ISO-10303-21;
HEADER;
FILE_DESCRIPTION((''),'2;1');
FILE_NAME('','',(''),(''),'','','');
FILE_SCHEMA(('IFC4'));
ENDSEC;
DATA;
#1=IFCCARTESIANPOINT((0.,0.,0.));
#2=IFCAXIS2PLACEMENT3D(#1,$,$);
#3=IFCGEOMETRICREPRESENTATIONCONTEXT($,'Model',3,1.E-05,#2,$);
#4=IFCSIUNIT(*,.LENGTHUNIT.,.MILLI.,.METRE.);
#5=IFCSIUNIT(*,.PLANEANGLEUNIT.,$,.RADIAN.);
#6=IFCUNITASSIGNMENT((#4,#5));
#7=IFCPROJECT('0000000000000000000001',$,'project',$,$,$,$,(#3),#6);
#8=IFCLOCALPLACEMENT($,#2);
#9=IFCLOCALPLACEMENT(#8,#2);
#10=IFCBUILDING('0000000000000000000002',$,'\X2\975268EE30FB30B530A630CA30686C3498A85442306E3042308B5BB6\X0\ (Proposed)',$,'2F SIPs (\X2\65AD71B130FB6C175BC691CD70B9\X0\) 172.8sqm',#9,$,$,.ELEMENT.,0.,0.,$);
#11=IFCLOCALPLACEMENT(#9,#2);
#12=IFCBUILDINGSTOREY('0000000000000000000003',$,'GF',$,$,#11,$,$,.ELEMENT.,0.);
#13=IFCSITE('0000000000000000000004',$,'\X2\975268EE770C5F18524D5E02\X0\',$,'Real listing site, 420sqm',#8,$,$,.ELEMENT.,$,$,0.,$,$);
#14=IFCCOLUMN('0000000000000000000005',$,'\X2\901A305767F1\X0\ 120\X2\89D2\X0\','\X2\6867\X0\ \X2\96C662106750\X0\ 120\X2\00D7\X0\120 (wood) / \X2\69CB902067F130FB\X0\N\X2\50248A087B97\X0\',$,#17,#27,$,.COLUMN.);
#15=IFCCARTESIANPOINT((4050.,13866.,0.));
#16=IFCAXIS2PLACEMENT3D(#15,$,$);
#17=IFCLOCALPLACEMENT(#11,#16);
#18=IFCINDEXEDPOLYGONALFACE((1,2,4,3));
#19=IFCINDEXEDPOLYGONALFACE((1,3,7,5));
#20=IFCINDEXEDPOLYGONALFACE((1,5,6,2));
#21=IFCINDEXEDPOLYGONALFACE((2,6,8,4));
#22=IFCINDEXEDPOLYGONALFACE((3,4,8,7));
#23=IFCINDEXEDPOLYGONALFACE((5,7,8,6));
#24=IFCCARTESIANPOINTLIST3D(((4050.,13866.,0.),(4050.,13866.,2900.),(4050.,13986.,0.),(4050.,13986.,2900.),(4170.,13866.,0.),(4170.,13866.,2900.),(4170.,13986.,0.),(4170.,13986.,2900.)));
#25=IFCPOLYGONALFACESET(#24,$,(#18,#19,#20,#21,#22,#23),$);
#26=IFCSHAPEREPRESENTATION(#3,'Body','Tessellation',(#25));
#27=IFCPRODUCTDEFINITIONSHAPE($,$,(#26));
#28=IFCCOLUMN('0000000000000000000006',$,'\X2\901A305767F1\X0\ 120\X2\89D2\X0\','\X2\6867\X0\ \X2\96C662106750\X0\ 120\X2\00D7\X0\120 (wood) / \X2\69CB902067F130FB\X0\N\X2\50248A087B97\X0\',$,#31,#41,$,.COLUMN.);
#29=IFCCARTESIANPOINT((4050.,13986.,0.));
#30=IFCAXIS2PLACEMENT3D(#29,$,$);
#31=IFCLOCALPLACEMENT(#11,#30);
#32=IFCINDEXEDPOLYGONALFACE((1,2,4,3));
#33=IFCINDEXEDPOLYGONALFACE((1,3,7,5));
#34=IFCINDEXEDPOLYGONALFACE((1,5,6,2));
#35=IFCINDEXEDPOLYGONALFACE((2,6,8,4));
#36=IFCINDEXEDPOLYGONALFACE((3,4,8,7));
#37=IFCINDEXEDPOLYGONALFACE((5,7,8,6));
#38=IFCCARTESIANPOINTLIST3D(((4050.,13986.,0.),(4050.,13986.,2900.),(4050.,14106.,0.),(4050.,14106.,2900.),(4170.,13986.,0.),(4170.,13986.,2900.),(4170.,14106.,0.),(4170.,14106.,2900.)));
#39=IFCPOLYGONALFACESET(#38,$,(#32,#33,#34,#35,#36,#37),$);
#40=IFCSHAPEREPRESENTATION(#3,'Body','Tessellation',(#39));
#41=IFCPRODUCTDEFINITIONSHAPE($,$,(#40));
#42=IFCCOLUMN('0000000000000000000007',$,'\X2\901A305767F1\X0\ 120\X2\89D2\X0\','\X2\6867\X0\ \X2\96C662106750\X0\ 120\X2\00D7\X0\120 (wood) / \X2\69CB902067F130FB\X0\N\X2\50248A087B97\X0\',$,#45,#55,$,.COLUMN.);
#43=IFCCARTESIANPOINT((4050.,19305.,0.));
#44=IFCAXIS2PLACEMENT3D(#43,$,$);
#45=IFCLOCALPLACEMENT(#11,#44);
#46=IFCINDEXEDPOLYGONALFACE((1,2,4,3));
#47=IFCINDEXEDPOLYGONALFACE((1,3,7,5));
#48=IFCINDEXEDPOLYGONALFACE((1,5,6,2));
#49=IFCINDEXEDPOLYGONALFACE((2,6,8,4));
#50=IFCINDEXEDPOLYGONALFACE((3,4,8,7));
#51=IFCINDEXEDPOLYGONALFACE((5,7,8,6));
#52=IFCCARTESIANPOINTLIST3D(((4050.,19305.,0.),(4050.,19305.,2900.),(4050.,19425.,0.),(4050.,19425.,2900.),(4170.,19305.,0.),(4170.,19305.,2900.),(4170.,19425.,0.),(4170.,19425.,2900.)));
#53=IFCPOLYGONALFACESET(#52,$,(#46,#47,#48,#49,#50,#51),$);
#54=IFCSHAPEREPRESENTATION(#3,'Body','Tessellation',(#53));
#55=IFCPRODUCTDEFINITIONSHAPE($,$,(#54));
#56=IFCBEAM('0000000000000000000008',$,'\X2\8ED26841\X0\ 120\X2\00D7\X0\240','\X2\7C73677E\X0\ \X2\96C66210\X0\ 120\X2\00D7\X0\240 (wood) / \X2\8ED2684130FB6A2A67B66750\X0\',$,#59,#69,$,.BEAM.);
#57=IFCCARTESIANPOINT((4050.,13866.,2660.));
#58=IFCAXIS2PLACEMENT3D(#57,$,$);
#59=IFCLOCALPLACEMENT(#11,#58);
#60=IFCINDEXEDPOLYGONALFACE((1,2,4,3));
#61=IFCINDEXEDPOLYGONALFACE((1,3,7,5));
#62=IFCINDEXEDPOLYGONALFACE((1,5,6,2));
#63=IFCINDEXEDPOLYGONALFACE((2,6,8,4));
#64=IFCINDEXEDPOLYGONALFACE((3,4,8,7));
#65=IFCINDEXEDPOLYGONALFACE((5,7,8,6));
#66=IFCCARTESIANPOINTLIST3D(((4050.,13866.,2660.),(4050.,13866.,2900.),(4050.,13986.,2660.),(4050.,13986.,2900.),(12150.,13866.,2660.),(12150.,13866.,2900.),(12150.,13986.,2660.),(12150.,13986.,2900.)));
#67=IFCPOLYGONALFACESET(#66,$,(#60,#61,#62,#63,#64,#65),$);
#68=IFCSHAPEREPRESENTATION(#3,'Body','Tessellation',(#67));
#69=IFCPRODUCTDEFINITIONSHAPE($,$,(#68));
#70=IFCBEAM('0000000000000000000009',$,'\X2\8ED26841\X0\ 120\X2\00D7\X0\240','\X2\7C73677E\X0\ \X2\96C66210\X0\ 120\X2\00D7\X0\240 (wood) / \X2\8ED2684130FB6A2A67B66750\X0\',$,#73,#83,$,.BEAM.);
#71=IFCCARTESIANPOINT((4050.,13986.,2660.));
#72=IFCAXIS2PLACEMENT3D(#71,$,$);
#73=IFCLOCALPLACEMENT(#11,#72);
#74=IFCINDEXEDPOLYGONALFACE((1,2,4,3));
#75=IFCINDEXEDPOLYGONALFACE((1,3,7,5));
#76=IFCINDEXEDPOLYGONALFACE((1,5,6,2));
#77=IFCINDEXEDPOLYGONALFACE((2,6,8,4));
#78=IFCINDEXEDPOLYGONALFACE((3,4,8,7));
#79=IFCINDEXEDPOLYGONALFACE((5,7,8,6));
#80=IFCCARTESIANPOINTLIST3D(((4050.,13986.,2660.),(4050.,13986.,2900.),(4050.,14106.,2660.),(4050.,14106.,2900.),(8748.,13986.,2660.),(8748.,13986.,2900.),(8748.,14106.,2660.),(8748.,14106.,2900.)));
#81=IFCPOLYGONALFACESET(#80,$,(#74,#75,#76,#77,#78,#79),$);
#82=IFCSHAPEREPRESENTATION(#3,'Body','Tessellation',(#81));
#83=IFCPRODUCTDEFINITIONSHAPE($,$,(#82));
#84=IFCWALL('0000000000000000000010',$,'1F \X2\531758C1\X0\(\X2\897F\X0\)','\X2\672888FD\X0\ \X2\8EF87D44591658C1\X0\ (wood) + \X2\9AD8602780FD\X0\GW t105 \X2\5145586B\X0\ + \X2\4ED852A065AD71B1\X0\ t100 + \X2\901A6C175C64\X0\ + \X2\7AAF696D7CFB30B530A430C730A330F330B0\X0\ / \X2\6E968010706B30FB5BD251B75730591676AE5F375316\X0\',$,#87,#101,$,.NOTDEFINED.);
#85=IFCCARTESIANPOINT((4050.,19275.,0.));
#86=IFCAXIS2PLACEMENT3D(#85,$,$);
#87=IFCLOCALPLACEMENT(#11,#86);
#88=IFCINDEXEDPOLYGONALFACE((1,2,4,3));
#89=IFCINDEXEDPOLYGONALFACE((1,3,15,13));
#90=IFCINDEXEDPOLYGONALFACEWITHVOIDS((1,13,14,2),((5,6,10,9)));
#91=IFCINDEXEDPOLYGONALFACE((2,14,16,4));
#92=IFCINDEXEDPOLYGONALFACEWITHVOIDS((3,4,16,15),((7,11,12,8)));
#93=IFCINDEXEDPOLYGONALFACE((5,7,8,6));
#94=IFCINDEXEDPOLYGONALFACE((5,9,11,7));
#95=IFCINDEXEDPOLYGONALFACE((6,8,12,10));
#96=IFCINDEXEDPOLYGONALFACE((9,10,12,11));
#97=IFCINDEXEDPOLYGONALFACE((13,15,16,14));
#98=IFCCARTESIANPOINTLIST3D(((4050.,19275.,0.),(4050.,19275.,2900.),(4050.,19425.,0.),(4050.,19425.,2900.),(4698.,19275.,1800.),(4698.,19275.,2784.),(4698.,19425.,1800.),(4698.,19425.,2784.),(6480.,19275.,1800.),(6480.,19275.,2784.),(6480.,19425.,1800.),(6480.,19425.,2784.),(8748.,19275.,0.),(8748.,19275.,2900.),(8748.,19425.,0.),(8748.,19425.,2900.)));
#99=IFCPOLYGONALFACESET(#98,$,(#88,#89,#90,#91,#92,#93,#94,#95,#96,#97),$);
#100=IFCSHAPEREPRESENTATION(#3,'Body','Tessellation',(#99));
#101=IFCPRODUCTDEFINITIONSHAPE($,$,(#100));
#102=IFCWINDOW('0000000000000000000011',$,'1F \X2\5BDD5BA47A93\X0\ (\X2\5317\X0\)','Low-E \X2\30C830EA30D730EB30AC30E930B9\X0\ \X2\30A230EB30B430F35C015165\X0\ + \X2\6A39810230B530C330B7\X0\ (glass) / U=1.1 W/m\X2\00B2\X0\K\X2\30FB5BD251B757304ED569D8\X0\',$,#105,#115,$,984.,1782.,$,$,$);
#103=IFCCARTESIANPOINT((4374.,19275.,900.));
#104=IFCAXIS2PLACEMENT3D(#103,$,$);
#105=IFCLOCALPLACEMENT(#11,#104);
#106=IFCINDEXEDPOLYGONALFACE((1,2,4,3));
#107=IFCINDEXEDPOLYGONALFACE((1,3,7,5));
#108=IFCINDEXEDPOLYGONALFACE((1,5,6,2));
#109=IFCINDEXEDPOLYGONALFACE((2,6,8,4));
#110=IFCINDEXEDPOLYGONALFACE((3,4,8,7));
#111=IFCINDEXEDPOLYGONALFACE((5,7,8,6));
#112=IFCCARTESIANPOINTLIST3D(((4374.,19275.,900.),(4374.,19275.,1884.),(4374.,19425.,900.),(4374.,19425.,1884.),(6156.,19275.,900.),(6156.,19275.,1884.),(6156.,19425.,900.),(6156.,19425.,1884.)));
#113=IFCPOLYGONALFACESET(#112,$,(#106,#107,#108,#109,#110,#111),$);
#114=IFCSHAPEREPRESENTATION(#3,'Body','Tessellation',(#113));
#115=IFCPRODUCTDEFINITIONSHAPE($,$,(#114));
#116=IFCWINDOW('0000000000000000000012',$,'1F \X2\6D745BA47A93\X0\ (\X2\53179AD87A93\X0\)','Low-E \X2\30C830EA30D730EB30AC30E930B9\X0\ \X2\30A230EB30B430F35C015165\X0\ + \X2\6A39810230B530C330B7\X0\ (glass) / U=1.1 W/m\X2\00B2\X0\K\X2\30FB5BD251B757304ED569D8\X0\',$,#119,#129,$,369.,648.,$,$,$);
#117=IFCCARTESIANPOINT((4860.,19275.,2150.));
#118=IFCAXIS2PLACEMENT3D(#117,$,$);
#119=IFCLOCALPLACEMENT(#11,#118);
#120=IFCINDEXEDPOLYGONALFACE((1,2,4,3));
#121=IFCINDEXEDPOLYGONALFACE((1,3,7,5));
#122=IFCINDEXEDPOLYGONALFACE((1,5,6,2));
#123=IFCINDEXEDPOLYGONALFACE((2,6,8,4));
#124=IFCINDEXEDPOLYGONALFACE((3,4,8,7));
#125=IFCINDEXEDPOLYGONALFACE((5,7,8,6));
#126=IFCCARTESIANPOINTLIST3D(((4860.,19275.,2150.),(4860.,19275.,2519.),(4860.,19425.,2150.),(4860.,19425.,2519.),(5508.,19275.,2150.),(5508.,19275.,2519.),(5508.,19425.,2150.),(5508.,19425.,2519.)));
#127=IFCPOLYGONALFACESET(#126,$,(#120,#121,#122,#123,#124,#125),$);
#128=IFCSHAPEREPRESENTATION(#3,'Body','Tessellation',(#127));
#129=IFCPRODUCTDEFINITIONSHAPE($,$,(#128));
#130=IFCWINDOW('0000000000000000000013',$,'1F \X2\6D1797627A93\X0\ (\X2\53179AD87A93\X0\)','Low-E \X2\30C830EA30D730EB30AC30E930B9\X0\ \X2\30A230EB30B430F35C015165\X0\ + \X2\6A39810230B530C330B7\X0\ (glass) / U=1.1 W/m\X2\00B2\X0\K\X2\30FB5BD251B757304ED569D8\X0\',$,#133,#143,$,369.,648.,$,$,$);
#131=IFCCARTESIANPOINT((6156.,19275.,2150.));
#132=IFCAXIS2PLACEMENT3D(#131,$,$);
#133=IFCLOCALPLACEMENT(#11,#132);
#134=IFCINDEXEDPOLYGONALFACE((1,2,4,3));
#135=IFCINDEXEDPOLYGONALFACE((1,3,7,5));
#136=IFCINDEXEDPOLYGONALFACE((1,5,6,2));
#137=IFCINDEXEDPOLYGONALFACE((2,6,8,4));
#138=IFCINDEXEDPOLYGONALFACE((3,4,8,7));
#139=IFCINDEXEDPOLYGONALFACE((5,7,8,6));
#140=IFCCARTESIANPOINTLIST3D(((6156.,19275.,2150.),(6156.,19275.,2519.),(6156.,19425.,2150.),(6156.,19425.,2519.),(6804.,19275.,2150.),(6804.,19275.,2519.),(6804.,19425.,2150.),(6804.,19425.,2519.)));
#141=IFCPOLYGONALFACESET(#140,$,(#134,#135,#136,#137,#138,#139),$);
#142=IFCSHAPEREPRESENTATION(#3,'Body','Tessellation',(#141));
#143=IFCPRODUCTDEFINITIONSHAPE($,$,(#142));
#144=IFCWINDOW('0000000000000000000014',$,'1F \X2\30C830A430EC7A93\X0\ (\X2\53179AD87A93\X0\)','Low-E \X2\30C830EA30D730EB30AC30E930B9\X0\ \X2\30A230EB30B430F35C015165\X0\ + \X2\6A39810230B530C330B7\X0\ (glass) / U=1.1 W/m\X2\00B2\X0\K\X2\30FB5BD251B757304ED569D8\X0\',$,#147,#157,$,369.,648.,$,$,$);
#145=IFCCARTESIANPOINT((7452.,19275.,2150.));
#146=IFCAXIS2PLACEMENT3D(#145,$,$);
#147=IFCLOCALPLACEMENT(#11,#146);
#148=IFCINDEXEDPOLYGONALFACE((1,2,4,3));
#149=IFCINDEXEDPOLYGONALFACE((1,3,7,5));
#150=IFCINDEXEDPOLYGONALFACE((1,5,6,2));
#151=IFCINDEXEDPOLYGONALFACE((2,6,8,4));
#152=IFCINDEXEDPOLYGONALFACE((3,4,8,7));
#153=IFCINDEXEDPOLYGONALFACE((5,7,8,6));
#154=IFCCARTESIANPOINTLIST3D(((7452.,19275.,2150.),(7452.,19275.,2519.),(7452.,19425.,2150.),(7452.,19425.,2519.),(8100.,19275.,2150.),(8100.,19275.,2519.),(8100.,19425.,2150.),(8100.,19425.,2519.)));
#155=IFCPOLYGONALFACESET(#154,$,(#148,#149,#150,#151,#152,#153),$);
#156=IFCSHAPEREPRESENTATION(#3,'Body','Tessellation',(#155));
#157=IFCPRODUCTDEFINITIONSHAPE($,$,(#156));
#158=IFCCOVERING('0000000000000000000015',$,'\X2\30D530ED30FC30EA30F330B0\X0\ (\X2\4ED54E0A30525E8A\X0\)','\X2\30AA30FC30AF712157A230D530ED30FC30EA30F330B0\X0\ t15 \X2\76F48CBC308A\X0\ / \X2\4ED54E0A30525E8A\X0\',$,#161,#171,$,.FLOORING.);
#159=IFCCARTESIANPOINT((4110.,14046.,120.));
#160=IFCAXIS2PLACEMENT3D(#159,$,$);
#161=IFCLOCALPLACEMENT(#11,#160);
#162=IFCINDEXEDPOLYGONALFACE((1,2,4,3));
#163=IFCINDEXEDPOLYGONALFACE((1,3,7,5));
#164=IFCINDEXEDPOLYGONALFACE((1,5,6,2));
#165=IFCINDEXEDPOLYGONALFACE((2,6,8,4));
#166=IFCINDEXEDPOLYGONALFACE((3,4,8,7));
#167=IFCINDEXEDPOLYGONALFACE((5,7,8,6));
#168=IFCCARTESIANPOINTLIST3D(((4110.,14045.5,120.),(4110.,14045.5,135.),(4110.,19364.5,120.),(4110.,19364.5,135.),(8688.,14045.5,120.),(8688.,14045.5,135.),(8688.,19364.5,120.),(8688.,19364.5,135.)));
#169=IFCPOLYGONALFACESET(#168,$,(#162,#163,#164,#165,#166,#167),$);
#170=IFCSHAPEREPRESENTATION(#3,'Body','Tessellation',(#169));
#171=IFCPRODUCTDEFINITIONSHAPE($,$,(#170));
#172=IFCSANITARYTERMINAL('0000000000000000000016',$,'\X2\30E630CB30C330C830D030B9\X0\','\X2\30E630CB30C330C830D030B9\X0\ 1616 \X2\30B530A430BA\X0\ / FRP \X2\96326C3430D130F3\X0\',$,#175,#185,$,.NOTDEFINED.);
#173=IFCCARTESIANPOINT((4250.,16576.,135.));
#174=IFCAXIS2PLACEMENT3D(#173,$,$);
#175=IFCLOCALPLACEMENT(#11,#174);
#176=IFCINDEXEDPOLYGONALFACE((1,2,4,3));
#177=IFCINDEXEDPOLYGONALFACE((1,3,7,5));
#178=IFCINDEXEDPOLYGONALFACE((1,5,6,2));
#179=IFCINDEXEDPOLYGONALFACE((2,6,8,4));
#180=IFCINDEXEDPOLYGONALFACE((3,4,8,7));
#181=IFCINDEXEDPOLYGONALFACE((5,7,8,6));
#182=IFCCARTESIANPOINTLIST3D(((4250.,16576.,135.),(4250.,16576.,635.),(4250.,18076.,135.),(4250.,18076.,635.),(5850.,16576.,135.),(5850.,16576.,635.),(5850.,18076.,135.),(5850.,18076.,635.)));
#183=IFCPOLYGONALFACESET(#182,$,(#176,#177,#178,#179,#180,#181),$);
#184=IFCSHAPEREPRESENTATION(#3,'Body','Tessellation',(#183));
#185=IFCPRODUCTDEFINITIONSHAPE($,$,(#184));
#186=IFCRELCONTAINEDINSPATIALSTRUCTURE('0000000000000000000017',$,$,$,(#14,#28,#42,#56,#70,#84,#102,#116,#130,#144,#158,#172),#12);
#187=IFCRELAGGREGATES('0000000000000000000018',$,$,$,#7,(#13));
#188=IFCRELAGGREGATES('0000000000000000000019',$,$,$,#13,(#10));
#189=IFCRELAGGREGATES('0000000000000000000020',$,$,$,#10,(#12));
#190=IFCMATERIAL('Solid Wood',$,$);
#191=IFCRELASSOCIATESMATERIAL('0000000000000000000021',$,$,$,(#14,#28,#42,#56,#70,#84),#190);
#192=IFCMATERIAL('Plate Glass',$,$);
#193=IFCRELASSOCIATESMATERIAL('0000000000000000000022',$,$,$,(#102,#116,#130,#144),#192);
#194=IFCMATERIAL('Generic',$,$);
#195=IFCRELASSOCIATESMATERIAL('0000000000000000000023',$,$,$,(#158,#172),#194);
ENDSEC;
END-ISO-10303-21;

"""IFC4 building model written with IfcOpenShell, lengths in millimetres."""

from ifc_helpers import new_model, si_unit, frame, frame_2d, origin, place, context, project, spatial, rectangle, extrude, material, element, fill, save


model = new_model("IFC4")

# Units and contexts
model_context = context("Model", 3, precision=1e-05, world=origin())
ifc_project = project(units=[si_unit("LENGTHUNIT", "METRE", prefix="MILLI"), si_unit("PLANEANGLEUNIT", "RADIAN")], contexts=[model_context])

# Site, building, storey
site_placement = place(None, origin())
site = spatial("IfcSite", under=ifc_project, at=site_placement, Name="青森県弘前市", ObjectType="Real listing site, 420sqm", CompositionType="ELEMENT", RefElevation=0.0)
building_placement = place(site_placement, origin())
building = spatial("IfcBuilding", under=site, at=building_placement, Name="青森・サウナと水風呂のある家 (Proposed)", ObjectType="2F SIPs (断熱・気密重点) 172.8sqm", CompositionType="ELEMENT", ElevationOfRefHeight=0.0, ElevationOfTerrain=0.0)
storey_placement = place(building_placement, origin())
storey = spatial("IfcBuildingStorey", under=building, at=storey_placement, Name="GF", CompositionType="ELEMENT", Elevation=0.0)

# Columns
ifc_material_1 = material(Name="Solid Wood")
column_1_placement = place(storey_placement, frame((4050.0, 13866.0, 0.0)))
element("IfcColumn", 1, at=column_1_placement, inside=storey, material=ifc_material_1, Name="通し柱 120角", Description="桧 集成材 120×120 (wood) / 構造柱・N値計算", PredefinedType="COLUMN", context=model_context, shape_type="SweptSolid", body=[
    extrude(rectangle(XDim=120.0, YDim=120.0, at=frame_2d((60.0, 60.0))), frame((4050.0, 13866.0, 0.0)), (0.0, 0.0, 1.0), 2900.0),
])
column_2_placement = place(storey_placement, frame((4050.0, 13986.0, 0.0)))
element("IfcColumn", 2, at=column_2_placement, inside=storey, material=ifc_material_1, Name="通し柱 120角", Description="桧 集成材 120×120 (wood) / 構造柱・N値計算", PredefinedType="COLUMN", context=model_context, shape_type="SweptSolid", body=[
    extrude(rectangle(XDim=120.0, YDim=120.0, at=frame_2d((60.0, 60.0))), frame((4050.0, 13986.0, 0.0)), (0.0, 0.0, 1.0), 2900.0),
])
column_3_placement = place(storey_placement, frame((4050.0, 19305.0, 0.0)))
element("IfcColumn", 3, at=column_3_placement, inside=storey, material=ifc_material_1, Name="通し柱 120角", Description="桧 集成材 120×120 (wood) / 構造柱・N値計算", PredefinedType="COLUMN", context=model_context, shape_type="SweptSolid", body=[
    extrude(rectangle(XDim=120.0, YDim=120.0, at=frame_2d((60.0, 60.0))), frame((4050.0, 19305.0, 0.0)), (0.0, 0.0, 1.0), 2900.0),
])

# Beams
beam_1_placement = place(storey_placement, frame((4050.0, 13866.0, 2660.0)))
element("IfcBeam", 4, at=beam_1_placement, inside=storey, material=ifc_material_1, Name="軒桁 120×240", Description="米松 集成 120×240 (wood) / 軒桁・横架材", PredefinedType="BEAM", context=model_context, shape_type="SweptSolid", body=[
    extrude(rectangle(XDim=8100.0, YDim=120.0, at=frame_2d((4050.0, 60.0))), frame((4050.0, 13866.0, 2660.0)), (0.0, 0.0, 1.0), 240.0),
])
beam_2_placement = place(storey_placement, frame((4050.0, 13986.0, 2660.0)))
element("IfcBeam", 5, at=beam_2_placement, inside=storey, material=ifc_material_1, Name="軒桁 120×240", Description="米松 集成 120×240 (wood) / 軒桁・横架材", PredefinedType="BEAM", context=model_context, shape_type="SweptSolid", body=[
    extrude(rectangle(XDim=4698.0, YDim=120.0, at=frame_2d((2349.0, 60.0))), frame((4050.0, 13986.0, 2660.0)), (0.0, 0.0, 1.0), 240.0),
])

# Wall, openings, windows
wall_1_placement = place(storey_placement, frame((4050.0, 19275.0, 0.0)))
wall_1 = element("IfcWall", 6, at=wall_1_placement, inside=storey, material=ifc_material_1, Name="1F 北壁(西)", Description="木製 軸組外壁 (wood) + 高性能GW t105 充填 + 付加断熱 t100 + 通気層 + 窯業系サイディング / 準耐火・寒冷地外皮強化", PredefinedType="NOTDEFINED", context=model_context, shape_type="SweptSolid", body=[
    extrude(rectangle(XDim=4698.0, YDim=150.0, at=frame_2d((2349.0, 75.0))), frame((4050.0, 19275.0, 0.0)), (0.0, 0.0, 1.0), 2900.0),
])
opening_1_placement = place(storey_placement, frame((4374.0, 19275.0, 900.0)))
opening_1 = element("IfcOpeningElement", 7, at=opening_1_placement, cuts=wall_1, PredefinedType="NOTDEFINED", context=model_context, shape_type="SweptSolid", body=[
    extrude(rectangle(XDim=1782.0, YDim=150.0, at=frame_2d((891.0, 75.0))), frame((4374.0, 19275.0, 900.0)), (0.0, 0.0, 1.0), 984.0),
])
opening_2_placement = place(storey_placement, frame((4860.0, 19275.0, 2150.0)))
opening_2 = element("IfcOpeningElement", 8, at=opening_2_placement, cuts=wall_1, PredefinedType="NOTDEFINED", context=model_context, shape_type="SweptSolid", body=[
    extrude(rectangle(XDim=648.0, YDim=150.0, at=frame_2d((324.0, 75.0))), frame((4860.0, 19275.0, 2150.0)), (0.0, 0.0, 1.0), 369.0),
])
opening_3_placement = place(storey_placement, frame((6156.0, 19275.0, 2150.0)))
opening_3 = element("IfcOpeningElement", 9, at=opening_3_placement, cuts=wall_1, PredefinedType="NOTDEFINED", context=model_context, shape_type="SweptSolid", body=[
    extrude(rectangle(XDim=648.0, YDim=150.0, at=frame_2d((324.0, 75.0))), frame((6156.0, 19275.0, 2150.0)), (0.0, 0.0, 1.0), 369.0),
])
opening_4_placement = place(storey_placement, frame((7452.0, 19275.0, 2150.0)))
opening_4 = element("IfcOpeningElement", 10, at=opening_4_placement, cuts=wall_1, PredefinedType="NOTDEFINED", context=model_context, shape_type="SweptSolid", body=[
    extrude(rectangle(XDim=648.0, YDim=150.0, at=frame_2d((324.0, 75.0))), frame((7452.0, 19275.0, 2150.0)), (0.0, 0.0, 1.0), 369.0),
])
ifc_material_2 = material(Name="Plate Glass")
window_1_placement = place(storey_placement, frame((4374.0, 19275.0, 900.0)))
window_1 = element("IfcWindow", 11, at=window_1_placement, inside=storey, material=ifc_material_2, Name="1F 寝室窓 (北)", Description="Low-E トリプルガラス アルゴン封入 + 樹脂サッシ (glass) / U=1.1 W/m²K・寒冷地仕様", OverallHeight=984.0, OverallWidth=1782.0, context=model_context, shape_type="SweptSolid", body=[
    extrude(rectangle(XDim=1782.0, YDim=150.0, at=frame_2d((891.0, 75.0))), frame((4374.0, 19275.0, 900.0)), (0.0, 0.0, 1.0), 984.0),
])
fill(opening_1, window_1)
window_2_placement = place(storey_placement, frame((4860.0, 19275.0, 2150.0)))
window_2 = element("IfcWindow", 12, at=window_2_placement, inside=storey, material=ifc_material_2, Name="1F 浴室窓 (北高窓)", Description="Low-E トリプルガラス アルゴン封入 + 樹脂サッシ (glass) / U=1.1 W/m²K・寒冷地仕様", OverallHeight=369.0, OverallWidth=648.0, context=model_context, shape_type="SweptSolid", body=[
    extrude(rectangle(XDim=648.0, YDim=150.0, at=frame_2d((324.0, 75.0))), frame((4860.0, 19275.0, 2150.0)), (0.0, 0.0, 1.0), 369.0),
])
fill(opening_2, window_2)
window_3_placement = place(storey_placement, frame((6156.0, 19275.0, 2150.0)))
window_3 = element("IfcWindow", 13, at=window_3_placement, inside=storey, material=ifc_material_2, Name="1F 洗面窓 (北高窓)", Description="Low-E トリプルガラス アルゴン封入 + 樹脂サッシ (glass) / U=1.1 W/m²K・寒冷地仕様", OverallHeight=369.0, OverallWidth=648.0, context=model_context, shape_type="SweptSolid", body=[
    extrude(rectangle(XDim=648.0, YDim=150.0, at=frame_2d((324.0, 75.0))), frame((6156.0, 19275.0, 2150.0)), (0.0, 0.0, 1.0), 369.0),
])
fill(opening_3, window_3)
window_4_placement = place(storey_placement, frame((7452.0, 19275.0, 2150.0)))
window_4 = element("IfcWindow", 14, at=window_4_placement, inside=storey, material=ifc_material_2, Name="1F トイレ窓 (北高窓)", Description="Low-E トリプルガラス アルゴン封入 + 樹脂サッシ (glass) / U=1.1 W/m²K・寒冷地仕様", OverallHeight=369.0, OverallWidth=648.0, context=model_context, shape_type="SweptSolid", body=[
    extrude(rectangle(XDim=648.0, YDim=150.0, at=frame_2d((324.0, 75.0))), frame((7452.0, 19275.0, 2150.0)), (0.0, 0.0, 1.0), 369.0),
])
fill(opening_4, window_4)

# Covering
ifc_material_3 = material(Name="Generic")
covering_placement = place(storey_placement, frame((4110.0, 14046.0, 120.0)))
element("IfcCovering", 15, at=covering_placement, inside=storey, material=ifc_material_3, Name="フローリング (仕上げ床)", Description="オーク無垢フローリング t15 直貼り / 仕上げ床", PredefinedType="FLOORING", context=model_context, shape_type="SweptSolid", body=[
    extrude(rectangle(XDim=4578.0, YDim=5319.0, at=frame_2d((2289.0, 2659.0))), frame((4110.0, 14046.0, 120.0)), (0.0, 0.0, 1.0), 15.0),
])

# Sanitary terminal
sanitary_terminal_placement = place(storey_placement, frame((4250.0, 16576.0, 135.0)))
element("IfcSanitaryTerminal", 16, at=sanitary_terminal_placement, inside=storey, material=ifc_material_3, Name="ユニットバス", Description="ユニットバス 1616 サイズ / FRP 防水パン", PredefinedType="NOTDEFINED", context=model_context, shape_type="SweptSolid", body=[
    extrude(rectangle(XDim=1600.0, YDim=1500.0, at=frame_2d((800.0, 750.0))), frame((4250.0, 16576.0, 135.0)), (0.0, 0.0, 1.0), 500.0),
])

save(model, "model.ifc")
